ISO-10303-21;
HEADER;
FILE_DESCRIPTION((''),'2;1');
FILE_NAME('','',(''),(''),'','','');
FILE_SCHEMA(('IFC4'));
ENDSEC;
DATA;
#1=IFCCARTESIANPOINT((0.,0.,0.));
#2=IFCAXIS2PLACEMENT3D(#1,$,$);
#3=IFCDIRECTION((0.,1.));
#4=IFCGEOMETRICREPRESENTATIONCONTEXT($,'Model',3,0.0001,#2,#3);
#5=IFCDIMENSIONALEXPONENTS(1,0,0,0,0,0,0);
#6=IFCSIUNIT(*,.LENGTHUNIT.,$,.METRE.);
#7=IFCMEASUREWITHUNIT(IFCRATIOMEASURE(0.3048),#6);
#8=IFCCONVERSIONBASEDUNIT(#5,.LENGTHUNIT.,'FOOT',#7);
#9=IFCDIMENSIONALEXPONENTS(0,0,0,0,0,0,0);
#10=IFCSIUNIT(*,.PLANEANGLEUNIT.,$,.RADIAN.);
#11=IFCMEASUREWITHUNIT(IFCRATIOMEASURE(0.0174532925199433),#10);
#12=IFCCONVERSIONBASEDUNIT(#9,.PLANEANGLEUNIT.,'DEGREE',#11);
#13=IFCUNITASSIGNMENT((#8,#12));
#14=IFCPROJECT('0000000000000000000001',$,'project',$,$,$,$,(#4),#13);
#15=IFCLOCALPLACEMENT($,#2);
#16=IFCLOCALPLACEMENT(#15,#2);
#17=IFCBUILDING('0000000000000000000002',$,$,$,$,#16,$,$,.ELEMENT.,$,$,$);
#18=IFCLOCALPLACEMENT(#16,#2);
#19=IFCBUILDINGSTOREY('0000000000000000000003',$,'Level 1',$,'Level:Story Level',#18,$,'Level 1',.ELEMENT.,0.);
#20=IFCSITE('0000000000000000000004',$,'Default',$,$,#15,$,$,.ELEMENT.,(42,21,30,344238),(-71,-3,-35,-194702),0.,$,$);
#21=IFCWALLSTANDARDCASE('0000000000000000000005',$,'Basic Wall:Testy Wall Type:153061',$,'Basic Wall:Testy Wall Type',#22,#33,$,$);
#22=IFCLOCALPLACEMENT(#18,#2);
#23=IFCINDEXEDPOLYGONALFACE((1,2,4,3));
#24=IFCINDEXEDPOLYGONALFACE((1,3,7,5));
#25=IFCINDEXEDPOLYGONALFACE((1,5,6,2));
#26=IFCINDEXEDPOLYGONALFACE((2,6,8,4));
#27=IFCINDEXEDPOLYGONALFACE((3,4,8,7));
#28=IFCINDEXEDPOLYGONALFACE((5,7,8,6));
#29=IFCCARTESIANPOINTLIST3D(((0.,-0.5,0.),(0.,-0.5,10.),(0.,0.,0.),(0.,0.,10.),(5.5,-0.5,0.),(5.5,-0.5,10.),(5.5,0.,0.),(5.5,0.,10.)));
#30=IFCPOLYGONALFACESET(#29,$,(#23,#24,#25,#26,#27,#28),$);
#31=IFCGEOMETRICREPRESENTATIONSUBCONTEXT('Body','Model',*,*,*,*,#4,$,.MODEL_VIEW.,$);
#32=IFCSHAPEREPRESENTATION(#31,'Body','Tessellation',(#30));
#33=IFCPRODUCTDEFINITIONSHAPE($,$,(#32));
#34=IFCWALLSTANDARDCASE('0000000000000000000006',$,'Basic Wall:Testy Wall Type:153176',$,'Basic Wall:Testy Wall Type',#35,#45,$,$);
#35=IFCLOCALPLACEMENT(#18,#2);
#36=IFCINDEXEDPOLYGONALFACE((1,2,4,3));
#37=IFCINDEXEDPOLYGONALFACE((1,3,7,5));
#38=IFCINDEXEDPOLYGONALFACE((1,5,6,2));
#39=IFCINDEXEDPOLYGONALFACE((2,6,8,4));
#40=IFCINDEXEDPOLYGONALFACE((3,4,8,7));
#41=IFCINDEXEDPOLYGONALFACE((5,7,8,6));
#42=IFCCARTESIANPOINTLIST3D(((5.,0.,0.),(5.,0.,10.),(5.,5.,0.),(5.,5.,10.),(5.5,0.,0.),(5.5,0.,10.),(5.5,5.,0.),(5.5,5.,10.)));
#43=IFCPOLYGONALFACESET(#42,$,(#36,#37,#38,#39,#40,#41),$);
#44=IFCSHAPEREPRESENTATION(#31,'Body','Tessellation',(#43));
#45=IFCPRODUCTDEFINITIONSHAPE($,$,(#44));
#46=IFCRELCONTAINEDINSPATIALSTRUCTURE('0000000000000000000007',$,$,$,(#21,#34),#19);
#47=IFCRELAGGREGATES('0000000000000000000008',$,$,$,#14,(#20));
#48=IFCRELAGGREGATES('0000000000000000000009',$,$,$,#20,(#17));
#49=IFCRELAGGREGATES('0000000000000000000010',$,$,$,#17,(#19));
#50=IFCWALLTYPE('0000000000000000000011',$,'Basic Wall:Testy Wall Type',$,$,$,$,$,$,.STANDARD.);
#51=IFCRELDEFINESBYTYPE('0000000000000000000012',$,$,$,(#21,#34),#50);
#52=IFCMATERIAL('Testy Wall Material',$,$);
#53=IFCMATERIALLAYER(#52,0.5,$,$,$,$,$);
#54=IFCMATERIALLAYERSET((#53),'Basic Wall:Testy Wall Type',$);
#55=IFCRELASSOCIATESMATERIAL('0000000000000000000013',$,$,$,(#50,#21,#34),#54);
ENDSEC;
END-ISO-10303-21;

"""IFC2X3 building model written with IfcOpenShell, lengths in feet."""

from ifc_helpers import new_model, entity, si_unit, converted_unit, direction, frame, frame_2d, origin, place, context, subcontext, project, spatial, rectangle, extrude, material, layer, layer_set, layer_usage, type_object, element, save


model = new_model("IFC2X3")

# Units and contexts
model_context = context("Model", 3, precision=0.0001, world=origin(), true_north=direction((0.0, 1.0)))
body_context = subcontext(model_context, "Body", "Model", "MODEL_VIEW")
ifc_project = project(units=[converted_unit("LENGTHUNIT", "FOOT", entity("IfcRatioMeasure", 0.3048), si_unit("LENGTHUNIT", "METRE"), dimensions=[1, 0, 0, 0, 0, 0, 0]), converted_unit("PLANEANGLEUNIT", "DEGREE", entity("IfcRatioMeasure", 0.0174532925199433), si_unit("PLANEANGLEUNIT", "RADIAN"), dimensions=[0, 0, 0, 0, 0, 0, 0])], contexts=[model_context])

# Site, building, storey
site_placement = place(None, origin())
site = spatial("IfcSite", under=ifc_project, at=site_placement, Name="Default", CompositionType="ELEMENT", RefLatitude=(42, 21, 30, 344238), RefLongitude=(-71, -3, -35, -194702), RefElevation=0.0)
building_placement = place(site_placement, origin())
building = spatial("IfcBuilding", under=site, at=building_placement, CompositionType="ELEMENT")
storey_placement = place(building_placement, origin())
storey = spatial("IfcBuildingStorey", under=building, at=storey_placement, Name="Level 1", ObjectType="Level:Story Level", LongName="Level 1", CompositionType="ELEMENT", Elevation=0.0)

# Walls
ifc_material = material(Name="Testy Wall Material")
ifc_layer = layer(ifc_material, 0.5)
ifc_layer_set = layer_set([ifc_layer], Name="Basic Wall:Testy Wall Type")
ifc_layer_usage_1 = layer_usage(ifc_layer_set, "AXIS2", "NEGATIVE", 0.25)
wall_type = type_object("IfcWallType", Name="Basic Wall:Testy Wall Type", PredefinedType="STANDARD", material=ifc_layer_set)
wall_1_placement = place(storey_placement, frame((0.0, -0.25, 0.0)))
element("IfcWallStandardCase", 1, at=wall_1_placement, inside=storey, type_object=wall_type, material=ifc_layer_usage_1, Name="Basic Wall:Testy Wall Type:153061", ObjectType="Basic Wall:Testy Wall Type", context=body_context, shape_type="SweptSolid", body=[
    extrude(rectangle(XDim=5.5, YDim=0.5, at=frame_2d((2.75, 0.0), x_axis=(-1.0, 0.0))), origin(), (0.0, 0.0, 1.0), 10.0),
])
ifc_layer_usage_2 = layer_usage(ifc_layer_set, "AXIS2", "NEGATIVE", 0.25)
wall_2_placement = place(storey_placement, frame((5.25, 0.0, 0.0), z_axis=(0.0, 0.0, 1.0), x_axis=(0.0, 1.0, 0.0)))
element("IfcWallStandardCase", 2, at=wall_2_placement, inside=storey, type_object=wall_type, material=ifc_layer_usage_2, Name="Basic Wall:Testy Wall Type:153176", ObjectType="Basic Wall:Testy Wall Type", context=body_context, shape_type="SweptSolid", body=[
    extrude(rectangle(XDim=5.0, YDim=0.5, at=frame_2d((2.5, 0.0), x_axis=(-1.0, 0.0))), origin(), (0.0, 0.0, 1.0), 10.0),
])

save(model, "model.ifc")
